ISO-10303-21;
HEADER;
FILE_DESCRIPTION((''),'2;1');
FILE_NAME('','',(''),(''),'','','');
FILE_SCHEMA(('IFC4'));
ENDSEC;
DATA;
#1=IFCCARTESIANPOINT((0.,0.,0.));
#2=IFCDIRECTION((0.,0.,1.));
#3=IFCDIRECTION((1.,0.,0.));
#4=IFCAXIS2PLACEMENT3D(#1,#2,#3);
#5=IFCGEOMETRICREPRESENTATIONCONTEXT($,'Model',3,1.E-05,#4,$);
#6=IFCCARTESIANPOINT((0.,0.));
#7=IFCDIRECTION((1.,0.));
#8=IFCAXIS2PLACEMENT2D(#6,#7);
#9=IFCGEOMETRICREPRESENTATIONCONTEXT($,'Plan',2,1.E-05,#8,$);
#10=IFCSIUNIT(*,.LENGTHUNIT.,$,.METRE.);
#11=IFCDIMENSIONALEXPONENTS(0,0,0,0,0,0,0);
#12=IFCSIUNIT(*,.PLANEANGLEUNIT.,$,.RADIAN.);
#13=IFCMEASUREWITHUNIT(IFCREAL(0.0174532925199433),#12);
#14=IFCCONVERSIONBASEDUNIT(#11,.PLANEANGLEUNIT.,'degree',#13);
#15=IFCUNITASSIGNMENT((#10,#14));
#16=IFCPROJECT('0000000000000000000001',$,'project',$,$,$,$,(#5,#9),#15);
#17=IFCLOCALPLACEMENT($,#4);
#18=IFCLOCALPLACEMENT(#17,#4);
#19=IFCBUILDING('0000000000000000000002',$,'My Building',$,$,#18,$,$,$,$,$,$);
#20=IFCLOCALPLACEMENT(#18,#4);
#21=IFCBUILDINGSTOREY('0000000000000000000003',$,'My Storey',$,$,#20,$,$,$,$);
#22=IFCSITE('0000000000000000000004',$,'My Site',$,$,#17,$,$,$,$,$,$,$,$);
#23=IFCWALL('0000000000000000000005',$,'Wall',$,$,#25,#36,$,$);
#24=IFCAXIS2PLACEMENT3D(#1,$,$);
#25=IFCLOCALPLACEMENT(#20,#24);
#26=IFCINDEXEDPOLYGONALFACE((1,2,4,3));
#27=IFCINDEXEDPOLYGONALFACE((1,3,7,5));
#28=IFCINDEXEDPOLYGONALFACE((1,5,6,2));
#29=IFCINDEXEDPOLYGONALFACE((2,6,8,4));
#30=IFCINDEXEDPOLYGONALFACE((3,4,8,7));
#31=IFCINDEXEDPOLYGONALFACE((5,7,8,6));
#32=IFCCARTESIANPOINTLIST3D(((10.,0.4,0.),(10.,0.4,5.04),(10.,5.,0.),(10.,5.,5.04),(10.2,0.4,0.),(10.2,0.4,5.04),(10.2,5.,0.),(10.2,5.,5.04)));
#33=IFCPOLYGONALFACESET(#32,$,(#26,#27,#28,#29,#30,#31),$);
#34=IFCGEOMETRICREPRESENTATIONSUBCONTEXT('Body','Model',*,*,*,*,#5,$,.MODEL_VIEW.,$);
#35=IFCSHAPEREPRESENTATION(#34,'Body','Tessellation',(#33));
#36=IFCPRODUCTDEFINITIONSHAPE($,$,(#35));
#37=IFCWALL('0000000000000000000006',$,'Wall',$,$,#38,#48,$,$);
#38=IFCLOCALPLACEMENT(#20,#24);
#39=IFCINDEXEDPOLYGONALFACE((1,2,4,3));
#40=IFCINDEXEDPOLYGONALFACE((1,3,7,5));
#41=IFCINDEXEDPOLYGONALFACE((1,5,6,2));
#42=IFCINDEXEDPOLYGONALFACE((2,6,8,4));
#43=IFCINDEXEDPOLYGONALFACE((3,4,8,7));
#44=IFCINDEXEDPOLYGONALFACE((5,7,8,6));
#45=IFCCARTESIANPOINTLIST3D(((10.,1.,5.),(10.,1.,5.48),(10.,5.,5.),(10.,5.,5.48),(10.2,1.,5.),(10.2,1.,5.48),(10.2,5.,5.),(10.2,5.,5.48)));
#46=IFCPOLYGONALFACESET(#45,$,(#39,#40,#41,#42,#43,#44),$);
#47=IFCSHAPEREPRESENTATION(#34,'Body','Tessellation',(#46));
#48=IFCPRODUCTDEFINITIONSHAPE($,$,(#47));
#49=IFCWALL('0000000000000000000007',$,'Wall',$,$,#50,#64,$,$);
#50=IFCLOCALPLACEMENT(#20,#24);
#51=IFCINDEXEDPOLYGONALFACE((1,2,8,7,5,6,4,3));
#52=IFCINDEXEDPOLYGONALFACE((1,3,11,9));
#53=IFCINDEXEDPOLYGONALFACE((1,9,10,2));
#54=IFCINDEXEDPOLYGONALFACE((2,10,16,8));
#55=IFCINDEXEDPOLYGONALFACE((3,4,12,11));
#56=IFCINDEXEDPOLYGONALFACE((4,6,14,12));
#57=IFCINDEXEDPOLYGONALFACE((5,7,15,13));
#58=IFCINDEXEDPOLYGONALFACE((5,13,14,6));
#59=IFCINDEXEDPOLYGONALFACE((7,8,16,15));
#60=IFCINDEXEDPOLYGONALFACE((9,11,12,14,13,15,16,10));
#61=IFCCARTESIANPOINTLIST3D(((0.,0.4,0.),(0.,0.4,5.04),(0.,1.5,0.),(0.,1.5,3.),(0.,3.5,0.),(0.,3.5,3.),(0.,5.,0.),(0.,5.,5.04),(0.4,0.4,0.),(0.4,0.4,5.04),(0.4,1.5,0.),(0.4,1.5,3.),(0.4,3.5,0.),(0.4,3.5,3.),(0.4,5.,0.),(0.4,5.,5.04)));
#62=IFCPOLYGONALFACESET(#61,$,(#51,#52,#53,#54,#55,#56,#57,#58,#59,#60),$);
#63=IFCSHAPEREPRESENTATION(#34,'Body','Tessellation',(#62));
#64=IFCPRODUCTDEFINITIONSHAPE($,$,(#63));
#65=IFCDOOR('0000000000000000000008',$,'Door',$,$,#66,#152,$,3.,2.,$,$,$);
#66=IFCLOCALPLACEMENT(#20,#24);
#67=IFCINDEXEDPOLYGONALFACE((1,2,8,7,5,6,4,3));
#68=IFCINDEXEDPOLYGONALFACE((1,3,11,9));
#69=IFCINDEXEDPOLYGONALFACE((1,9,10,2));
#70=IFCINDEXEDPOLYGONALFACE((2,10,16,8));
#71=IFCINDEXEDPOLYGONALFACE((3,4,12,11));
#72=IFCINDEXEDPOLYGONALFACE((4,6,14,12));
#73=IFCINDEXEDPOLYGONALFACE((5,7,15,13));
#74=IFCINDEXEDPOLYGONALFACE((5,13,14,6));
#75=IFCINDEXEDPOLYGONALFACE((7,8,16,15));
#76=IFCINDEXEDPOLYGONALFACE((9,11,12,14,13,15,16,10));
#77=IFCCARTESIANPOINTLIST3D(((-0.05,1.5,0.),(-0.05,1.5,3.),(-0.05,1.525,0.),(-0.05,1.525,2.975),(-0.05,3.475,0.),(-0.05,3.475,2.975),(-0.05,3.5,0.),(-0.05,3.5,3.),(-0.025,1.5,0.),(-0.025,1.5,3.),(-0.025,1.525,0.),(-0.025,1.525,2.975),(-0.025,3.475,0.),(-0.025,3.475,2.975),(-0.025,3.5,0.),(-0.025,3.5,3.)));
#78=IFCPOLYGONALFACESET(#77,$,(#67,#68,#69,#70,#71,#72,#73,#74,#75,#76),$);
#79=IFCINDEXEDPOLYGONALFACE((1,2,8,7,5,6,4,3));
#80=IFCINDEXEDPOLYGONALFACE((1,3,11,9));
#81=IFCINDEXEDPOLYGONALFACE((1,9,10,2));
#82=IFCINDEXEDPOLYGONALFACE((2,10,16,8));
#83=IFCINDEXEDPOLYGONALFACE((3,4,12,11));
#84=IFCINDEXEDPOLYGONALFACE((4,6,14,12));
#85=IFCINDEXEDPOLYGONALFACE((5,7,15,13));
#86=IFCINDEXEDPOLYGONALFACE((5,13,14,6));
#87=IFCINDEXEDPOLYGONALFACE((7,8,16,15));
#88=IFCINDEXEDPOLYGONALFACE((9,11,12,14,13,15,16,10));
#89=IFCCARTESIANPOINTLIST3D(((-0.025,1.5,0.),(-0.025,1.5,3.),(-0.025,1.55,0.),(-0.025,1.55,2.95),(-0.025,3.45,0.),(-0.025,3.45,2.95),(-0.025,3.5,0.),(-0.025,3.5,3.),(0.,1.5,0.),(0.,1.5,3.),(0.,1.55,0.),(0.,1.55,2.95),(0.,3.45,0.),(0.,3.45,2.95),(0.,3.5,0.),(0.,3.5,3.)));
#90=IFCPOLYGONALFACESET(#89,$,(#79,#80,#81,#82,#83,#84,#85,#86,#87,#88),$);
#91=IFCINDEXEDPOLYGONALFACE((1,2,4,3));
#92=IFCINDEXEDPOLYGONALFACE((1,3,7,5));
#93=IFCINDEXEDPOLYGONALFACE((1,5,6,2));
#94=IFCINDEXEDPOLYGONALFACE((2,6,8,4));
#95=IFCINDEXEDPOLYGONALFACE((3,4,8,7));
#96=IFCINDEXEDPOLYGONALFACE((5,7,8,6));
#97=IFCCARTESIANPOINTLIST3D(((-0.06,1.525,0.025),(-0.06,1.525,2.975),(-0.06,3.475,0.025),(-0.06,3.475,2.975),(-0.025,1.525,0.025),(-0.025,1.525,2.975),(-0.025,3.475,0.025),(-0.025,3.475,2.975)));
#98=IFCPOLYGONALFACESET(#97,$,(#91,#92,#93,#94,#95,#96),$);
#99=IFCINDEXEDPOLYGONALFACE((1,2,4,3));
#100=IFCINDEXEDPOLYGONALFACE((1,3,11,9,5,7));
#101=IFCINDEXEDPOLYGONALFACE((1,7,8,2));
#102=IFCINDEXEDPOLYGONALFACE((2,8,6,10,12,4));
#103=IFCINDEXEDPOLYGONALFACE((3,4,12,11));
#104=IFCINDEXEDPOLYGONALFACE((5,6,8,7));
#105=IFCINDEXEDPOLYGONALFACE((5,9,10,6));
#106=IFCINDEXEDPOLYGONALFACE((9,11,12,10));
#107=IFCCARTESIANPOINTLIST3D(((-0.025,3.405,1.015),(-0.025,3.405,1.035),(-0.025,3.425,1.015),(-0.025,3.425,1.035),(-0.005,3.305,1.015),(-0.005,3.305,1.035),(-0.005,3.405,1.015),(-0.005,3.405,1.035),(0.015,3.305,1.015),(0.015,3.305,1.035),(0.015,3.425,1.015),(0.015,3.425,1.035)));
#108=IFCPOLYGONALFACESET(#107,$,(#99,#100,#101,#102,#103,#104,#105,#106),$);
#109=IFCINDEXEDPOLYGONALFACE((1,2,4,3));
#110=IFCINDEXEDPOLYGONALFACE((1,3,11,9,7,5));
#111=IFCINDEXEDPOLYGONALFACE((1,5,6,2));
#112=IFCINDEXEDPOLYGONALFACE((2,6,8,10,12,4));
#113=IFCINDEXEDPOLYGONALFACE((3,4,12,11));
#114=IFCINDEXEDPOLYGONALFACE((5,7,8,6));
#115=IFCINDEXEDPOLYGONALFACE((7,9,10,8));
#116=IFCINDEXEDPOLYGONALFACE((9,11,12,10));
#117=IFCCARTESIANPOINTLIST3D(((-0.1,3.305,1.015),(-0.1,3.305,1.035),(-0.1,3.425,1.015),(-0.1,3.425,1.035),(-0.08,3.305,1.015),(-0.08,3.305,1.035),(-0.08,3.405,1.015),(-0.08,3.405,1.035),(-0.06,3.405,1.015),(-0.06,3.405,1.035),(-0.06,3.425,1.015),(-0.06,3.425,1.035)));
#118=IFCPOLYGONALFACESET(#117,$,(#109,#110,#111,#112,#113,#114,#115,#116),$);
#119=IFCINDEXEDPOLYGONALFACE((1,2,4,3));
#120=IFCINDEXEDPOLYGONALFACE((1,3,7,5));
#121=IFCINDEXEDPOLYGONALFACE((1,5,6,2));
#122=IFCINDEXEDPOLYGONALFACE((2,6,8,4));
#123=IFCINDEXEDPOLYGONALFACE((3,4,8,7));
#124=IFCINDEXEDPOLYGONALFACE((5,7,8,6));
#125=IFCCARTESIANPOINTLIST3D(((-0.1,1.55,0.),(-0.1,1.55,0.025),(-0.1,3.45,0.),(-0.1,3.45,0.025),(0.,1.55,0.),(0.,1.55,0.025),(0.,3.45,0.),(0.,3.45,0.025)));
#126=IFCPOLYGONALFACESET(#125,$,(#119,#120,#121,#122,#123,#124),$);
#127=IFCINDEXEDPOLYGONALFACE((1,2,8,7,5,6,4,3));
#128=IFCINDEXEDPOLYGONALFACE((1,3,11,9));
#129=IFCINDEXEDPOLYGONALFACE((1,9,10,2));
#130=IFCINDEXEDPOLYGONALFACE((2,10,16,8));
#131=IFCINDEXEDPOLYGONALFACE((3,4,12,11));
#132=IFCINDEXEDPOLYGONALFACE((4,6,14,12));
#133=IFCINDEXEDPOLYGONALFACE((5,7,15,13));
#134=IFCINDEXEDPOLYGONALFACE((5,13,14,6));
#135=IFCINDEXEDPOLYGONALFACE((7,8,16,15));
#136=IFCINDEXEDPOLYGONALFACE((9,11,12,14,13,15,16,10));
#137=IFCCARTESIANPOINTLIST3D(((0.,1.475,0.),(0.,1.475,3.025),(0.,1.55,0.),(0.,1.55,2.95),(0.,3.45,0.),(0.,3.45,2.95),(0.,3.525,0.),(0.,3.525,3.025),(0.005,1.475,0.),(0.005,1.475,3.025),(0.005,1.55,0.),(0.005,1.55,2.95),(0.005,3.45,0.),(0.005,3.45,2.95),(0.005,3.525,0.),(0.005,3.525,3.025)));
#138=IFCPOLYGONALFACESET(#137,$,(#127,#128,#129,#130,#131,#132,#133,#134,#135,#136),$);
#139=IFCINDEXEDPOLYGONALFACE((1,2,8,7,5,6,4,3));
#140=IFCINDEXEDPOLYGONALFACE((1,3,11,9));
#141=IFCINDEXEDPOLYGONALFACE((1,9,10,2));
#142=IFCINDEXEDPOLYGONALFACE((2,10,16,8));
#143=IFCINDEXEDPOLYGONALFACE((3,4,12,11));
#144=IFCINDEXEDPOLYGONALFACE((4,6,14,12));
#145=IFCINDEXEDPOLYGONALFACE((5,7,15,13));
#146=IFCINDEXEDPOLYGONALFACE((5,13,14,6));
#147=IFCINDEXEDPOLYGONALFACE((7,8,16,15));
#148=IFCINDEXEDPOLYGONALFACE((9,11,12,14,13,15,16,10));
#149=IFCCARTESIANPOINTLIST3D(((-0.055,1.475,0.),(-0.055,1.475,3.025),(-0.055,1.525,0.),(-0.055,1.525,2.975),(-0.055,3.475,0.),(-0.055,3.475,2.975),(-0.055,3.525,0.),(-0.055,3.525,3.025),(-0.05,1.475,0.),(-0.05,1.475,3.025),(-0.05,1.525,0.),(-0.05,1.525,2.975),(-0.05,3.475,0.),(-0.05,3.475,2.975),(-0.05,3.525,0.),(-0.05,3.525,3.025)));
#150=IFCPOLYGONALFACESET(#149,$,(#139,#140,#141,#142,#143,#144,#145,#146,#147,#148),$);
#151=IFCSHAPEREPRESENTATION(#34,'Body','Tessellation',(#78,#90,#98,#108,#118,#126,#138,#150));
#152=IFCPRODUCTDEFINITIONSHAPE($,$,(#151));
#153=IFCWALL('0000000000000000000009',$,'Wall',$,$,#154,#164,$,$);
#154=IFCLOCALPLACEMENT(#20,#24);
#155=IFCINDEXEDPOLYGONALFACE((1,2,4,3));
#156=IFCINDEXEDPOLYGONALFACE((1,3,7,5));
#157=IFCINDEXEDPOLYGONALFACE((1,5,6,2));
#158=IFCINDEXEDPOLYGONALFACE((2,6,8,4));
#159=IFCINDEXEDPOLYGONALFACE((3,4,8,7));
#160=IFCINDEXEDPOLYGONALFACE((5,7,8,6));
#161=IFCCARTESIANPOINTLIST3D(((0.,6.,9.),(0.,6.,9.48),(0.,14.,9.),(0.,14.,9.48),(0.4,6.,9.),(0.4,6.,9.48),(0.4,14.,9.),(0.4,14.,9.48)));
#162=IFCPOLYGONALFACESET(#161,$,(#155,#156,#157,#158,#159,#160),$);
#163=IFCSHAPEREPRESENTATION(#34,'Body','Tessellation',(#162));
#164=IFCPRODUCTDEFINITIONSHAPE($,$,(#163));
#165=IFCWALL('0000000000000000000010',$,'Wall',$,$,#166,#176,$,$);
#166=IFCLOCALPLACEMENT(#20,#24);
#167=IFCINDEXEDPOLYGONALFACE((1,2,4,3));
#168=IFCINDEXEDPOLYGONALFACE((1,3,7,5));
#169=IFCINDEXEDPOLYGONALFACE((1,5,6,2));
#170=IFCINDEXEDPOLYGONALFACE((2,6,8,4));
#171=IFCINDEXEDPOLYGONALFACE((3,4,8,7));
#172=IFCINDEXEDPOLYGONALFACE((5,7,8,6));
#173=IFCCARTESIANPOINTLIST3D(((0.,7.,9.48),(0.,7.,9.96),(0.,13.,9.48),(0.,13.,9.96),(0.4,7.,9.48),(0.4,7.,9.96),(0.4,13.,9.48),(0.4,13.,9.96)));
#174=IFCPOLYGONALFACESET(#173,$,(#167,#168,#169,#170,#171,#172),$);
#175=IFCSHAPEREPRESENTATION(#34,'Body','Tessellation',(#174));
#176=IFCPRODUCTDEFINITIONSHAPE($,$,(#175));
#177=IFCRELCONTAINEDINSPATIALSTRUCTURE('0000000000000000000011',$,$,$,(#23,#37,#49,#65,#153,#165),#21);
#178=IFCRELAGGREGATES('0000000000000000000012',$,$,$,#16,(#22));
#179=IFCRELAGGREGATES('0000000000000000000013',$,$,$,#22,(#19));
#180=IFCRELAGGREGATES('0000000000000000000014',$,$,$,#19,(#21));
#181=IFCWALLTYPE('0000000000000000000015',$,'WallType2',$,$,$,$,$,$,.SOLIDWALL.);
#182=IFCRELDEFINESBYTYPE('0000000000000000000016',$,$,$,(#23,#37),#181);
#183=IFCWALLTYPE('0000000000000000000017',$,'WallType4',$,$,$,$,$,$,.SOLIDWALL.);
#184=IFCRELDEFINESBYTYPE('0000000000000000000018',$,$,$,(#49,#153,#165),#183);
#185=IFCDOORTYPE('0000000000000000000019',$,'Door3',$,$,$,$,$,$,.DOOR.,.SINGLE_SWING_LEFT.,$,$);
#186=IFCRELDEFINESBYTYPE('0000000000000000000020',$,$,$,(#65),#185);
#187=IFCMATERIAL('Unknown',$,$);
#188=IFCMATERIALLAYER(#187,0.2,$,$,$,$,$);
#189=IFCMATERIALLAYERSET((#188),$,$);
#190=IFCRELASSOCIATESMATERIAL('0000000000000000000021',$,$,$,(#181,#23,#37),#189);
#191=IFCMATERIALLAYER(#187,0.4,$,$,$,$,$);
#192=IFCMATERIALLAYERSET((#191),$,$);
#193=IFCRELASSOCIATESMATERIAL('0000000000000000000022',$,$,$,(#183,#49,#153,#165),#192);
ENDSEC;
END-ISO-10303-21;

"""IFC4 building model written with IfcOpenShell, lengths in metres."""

from ifc_helpers import new_model, entity, si_unit, converted_unit, frame, origin_with_axes, origin_2d_with_axis, place, context, subcontext, project, spatial, line, indexed_curve, outline, extrude, shape, source, transform, mapped, material, layer, layer_set, layer_usage, type_object, type_shapes, element, fill, save


model = new_model("IFC4")

# Units and contexts
model_context = context("Model", 3, precision=1e-05, world=origin_with_axes())
plan_context = context("Plan", 2, precision=1e-05, world=origin_2d_with_axis())
body_context_1 = subcontext(model_context, "Body", "Model", "MODEL_VIEW")
body_context_2 = subcontext(plan_context, "Body", "Plan", "PLAN_VIEW")
ifc_project = project(units=[si_unit("LENGTHUNIT", "METRE"), converted_unit("PLANEANGLEUNIT", "degree", entity("IfcReal", 0.0174532925199433), si_unit("PLANEANGLEUNIT", "RADIAN"), dimensions=[0, 0, 0, 0, 0, 0, 0])], contexts=[model_context, plan_context])

# Site, building, storey
site_placement = place(None, origin_with_axes())
site = spatial("IfcSite", under=ifc_project, at=site_placement, Name="My Site")
building_placement = place(site_placement, origin_with_axes())
building = spatial("IfcBuilding", under=site, at=building_placement, Name="My Building")
storey_placement = place(building_placement, origin_with_axes())
storey = spatial("IfcBuildingStorey", under=building, at=storey_placement, Name="My Storey")

# Walls
ifc_material = material(Name="Unknown")
ifc_layer_1 = layer(ifc_material, 0.2)
ifc_layer_set_1 = layer_set([ifc_layer_1])
ifc_layer_usage_1 = layer_usage(ifc_layer_set_1, "AXIS2", "POSITIVE", 0.0)
wall_type_1 = type_object("IfcWallType", Name="WallType2", PredefinedType="SOLIDWALL", material=ifc_layer_set_1)
wall_1_placement = place(storey_placement, frame((10.2, 0.4, 0.0), z_axis=(0.0, 0.0, 1.0), x_axis=(0.0, 1.0, 0.0)))
element("IfcWall", 1, at=wall_1_placement, inside=storey, type_object=wall_type_1, material=ifc_layer_usage_1, Name="Wall", context=body_context_1, shape_type="SweptSolid", body=[
    extrude(outline(indexed_curve([(0.0, 0.0), (0.0, 0.2), (4.6, 0.2), (4.6, 0.0), (0.0, 0.0)], self_intersect=False)), origin_with_axes(), (0.0, 0.0, 1.0), 5.04),
])
ifc_layer_usage_2 = layer_usage(ifc_layer_set_1, "AXIS2", "POSITIVE", 0.0)
wall_2_placement = place(storey_placement, frame((10.2, 1.0, 5.0), z_axis=(0.0, 0.0, 1.0), x_axis=(0.0, 1.0, 0.0)))
element("IfcWall", 2, at=wall_2_placement, inside=storey, type_object=wall_type_1, material=ifc_layer_usage_2, Name="Wall", context=body_context_1, shape_type="SweptSolid", body=[
    extrude(outline(indexed_curve([(0.0, 0.0), (0.0, 0.2), (4.0, 0.2), (4.0, 0.0), (0.0, 0.0)], self_intersect=False)), origin_with_axes(), (0.0, 0.0, 1.0), 0.48),
])

# Shared definitions
ifc_layer_2 = layer(ifc_material, 0.4)
ifc_layer_set_2 = layer_set([ifc_layer_2])
wall_type_2 = type_object("IfcWallType", Name="WallType4", PredefinedType="SOLIDWALL", material=ifc_layer_set_2)

# Wall, opening, door
ifc_layer_usage_3 = layer_usage(ifc_layer_set_2, "AXIS2", "POSITIVE", 0.0)
wall_3_placement = place(storey_placement, frame((0.4, 0.4, 0.0), z_axis=(0.0, 0.0, 1.0), x_axis=(0.0, 1.0, 0.0)))
wall_3 = element("IfcWall", 3, at=wall_3_placement, inside=storey, type_object=wall_type_2, material=ifc_layer_usage_3, Name="Wall", context=body_context_1, shape_type="SweptSolid", body=[
    extrude(outline(indexed_curve([(0.0, 0.0), (0.0, 0.4), (4.6, 0.4), (4.6, 0.0), (0.0, 0.0)], self_intersect=False)), origin_with_axes(), (0.0, 0.0, 1.0), 5.04),
])
shared_shape_1 = source(origin_with_axes(), body_context_1, "Body", "SweptSolid", [
    extrude(outline(indexed_curve([(0.0, 0.0), (2.0, 0.0), (2.0, 3.0), (0.0, 3.0)], segments=[line(1, 2, 3, 4, 1)])), frame((0.0, -0.6, 0.0), z_axis=(0.0, -1.0, 0.0), x_axis=(1.0, 0.0, 0.0)), (0.0, 0.0, -1.0), 1.2),
])
opening_1_placement = place(wall_3_placement, frame((1.1, 0.0, 0.0), z_axis=(0.0, 0.0, 1.0), x_axis=(1.0, 0.0, 0.0)))
opening_1 = element("IfcOpeningElement", 4, at=opening_1_placement, cuts=wall_3, PredefinedType="OPENING", context=body_context_1, shape_type="MappedRepresentation", body=[
    mapped(shared_shape_1, transform((0.0, 0.0, 0.0), x_axis=(1.0, 0.0, 0.0), y_axis=(0.0, 1.0, 0.0), z_axis=(0.0, 0.0, 1.0), scale=1.0)),
])
door_type_1 = type_object("IfcDoorType", Name="Door3", OperationType="SINGLE_SWING_LEFT", PredefinedType="DOOR")
shared_shape_2 = source(origin_with_axes(), body_context_1, "Body", "SweptSolid", [
    extrude(outline(indexed_curve([(0.0, 0.0), (0.0, 3.0), (2.0, 3.0), (2.0, 0.0), (1.975, 0.0), (1.975, 2.975), (0.025, 2.975), (0.025, 0.0)], segments=[line(1, 2, 3, 4, 5, 6, 7, 8, 1)])), frame((0.0, 0.025, 0.0), z_axis=(0.0, -1.0, 0.0), x_axis=(1.0, 0.0, 0.0)), (0.0, 0.0, -1.0), 0.025),
    extrude(outline(indexed_curve([(0.0, 0.0), (0.0, 3.0), (2.0, 3.0), (2.0, 0.0), (1.95, 0.0), (1.95, 2.95), (0.05, 2.95), (0.05, 0.0)], segments=[line(1, 2, 3, 4, 5, 6, 7, 8, 1)])), frame((0.0, 0.0, 0.0), z_axis=(0.0, -1.0, 0.0), x_axis=(1.0, 0.0, 0.0)), (0.0, 0.0, -1.0), 0.025),
    extrude(outline(indexed_curve([(0.0, 0.0), (1.95, 0.0), (1.95, 0.035), (0.0, 0.035)], segments=[line(1, 2, 3, 4, 1)])), frame((0.025, 0.025, 0.025), z_axis=(0.0, 0.0, 1.0), x_axis=(1.0, 0.0, 0.0)), (0.0, 0.0, 1.0), 2.95),
    extrude(outline(indexed_curve([(0.0, 0.0), (0.0, -0.04), (-0.12, -0.04), (-0.12, -0.02), (-0.02, -0.02), (-0.02, 0.0)], segments=[line(1, 2, 3, 4, 5, 6, 1)])), frame((1.925, 0.025, 1.015), z_axis=(0.0, 0.0, 1.0), x_axis=(1.0, 0.0, 0.0)), (0.0, 0.0, 1.0), 0.02),
    extrude(outline(indexed_curve([(0.0, 0.0), (0.0, 0.04), (-0.12, 0.04), (-0.12, 0.02), (-0.02, 0.02), (-0.02, 0.0)], segments=[line(1, 2, 3, 4, 5, 6, 1)])), frame((1.925, 0.06, 1.015), z_axis=(0.0, 0.0, 1.0), x_axis=(1.0, 0.0, 0.0)), (0.0, 0.0, 1.0), 0.02),
    extrude(outline(indexed_curve([(0.0, 0.0), (1.9, 0.0), (1.9, 0.1), (0.0, 0.1)], segments=[line(1, 2, 3, 4, 1)])), frame((0.05, 0.0, 0.0), z_axis=(0.0, 0.0, 1.0), x_axis=(1.0, 0.0, 0.0)), (0.0, 0.0, 1.0), 0.025),
    extrude(outline(indexed_curve([(0.0, 0.0), (0.0, 3.025), (2.05, 3.025), (2.05, 0.0), (1.975, 0.0), (1.975, 2.95), (0.075, 2.95), (0.075, 0.0)], segments=[line(1, 2, 3, 4, 5, 6, 7, 8, 1)])), frame((-0.025, -0.005, 0.0), z_axis=(0.0, -1.0, 0.0), x_axis=(1.0, 0.0, 0.0)), (0.0, 0.0, -1.0), 0.005),
    extrude(outline(indexed_curve([(0.0, 0.0), (0.0, 3.025), (2.05, 3.025), (2.05, 0.0), (2.0, 0.0), (2.0, 2.975), (0.05, 2.975), (0.05, 0.0)], segments=[line(1, 2, 3, 4, 5, 6, 7, 8, 1)])), frame((-0.025, 0.05, 0.0), z_axis=(0.0, -1.0, 0.0), x_axis=(1.0, 0.0, 0.0)), (0.0, 0.0, -1.0), 0.005),
])
shared_shape_3 = source(origin_with_axes(), body_context_2, "Body", "Curve2D", [
    entity("IfcIndexedPolyCurve", entity("IfcCartesianPointList2D", [[0.0, 0.0], [0.0, 0.05], [0.025, 0.05], [0.025, 0.025], [0.05, 0.025], [0.05, 0.0]]), [entity("IfcLineIndex", [1, 2, 3, 4, 5, 6, 1])]),
    entity("IfcIndexedPolyCurve", entity("IfcCartesianPointList2D", [[2.0, 0.0], [2.0, 0.05], [1.975, 0.05], [1.975, 0.025], [1.95, 0.025], [1.95, 0.0]]), [entity("IfcLineIndex", [1, 2, 3, 4, 5, 6, 1])]),
    entity("IfcTrimmedCurve", entity("IfcEllipse", entity("IfcAxis2Placement2D", entity("IfcCartesianPoint", [0.06, 0.05]), entity("IfcDirection", [1.0, 0.0])), 1.915, 1.95), [entity("IfcCartesianPoint", [1.975, 0.05])], [entity("IfcCartesianPoint", [0.06, 2.0])], True, "CARTESIAN"),
    entity("IfcIndexedPolyCurve", entity("IfcCartesianPointList2D", [[0.025, 0.05], [0.06, 0.05], [0.06, 2.0], [0.025, 2.0]]), [entity("IfcLineIndex", [1, 2, 3, 4, 1])]),
])
type_shapes(door_type_1, [shared_shape_2, shared_shape_3])
door_1_placement = place(opening_1_placement, frame((0.0, 0.4, 0.0), z_axis=(0.0, 0.0, 1.0), x_axis=(1.0, 0.0, 0.0)))
door_1 = element("IfcDoor", 5, at=door_1_placement, inside=storey, type_object=door_type_1, Name="Door", OverallHeight=3.0, OverallWidth=2.0, shapes=[
    shape(body_context_1, "Body", "MappedRepresentation", [mapped(shared_shape_2, transform((0.0, 0.0, 0.0), x_axis=(1.0, 0.0, 0.0), y_axis=(0.0, 1.0, 0.0), z_axis=(0.0, 0.0, 1.0), scale=1.0))]),
    shape(body_context_2, "Body", "MappedRepresentation", [mapped(shared_shape_3, transform((0.0, 0.0, 0.0), x_axis=(1.0, 0.0, 0.0), y_axis=(0.0, 1.0, 0.0), z_axis=(0.0, 0.0, 1.0), scale=1.0))]),
])
fill(opening_1, door_1)

# Walls
ifc_layer_usage_4 = layer_usage(ifc_layer_set_2, "AXIS2", "POSITIVE", 0.0)
wall_4_placement = place(storey_placement, frame((0.4, 6.0, 9.0), z_axis=(0.0, 0.0, 1.0), x_axis=(0.0, 1.0, 0.0)))
element("IfcWall", 6, at=wall_4_placement, inside=storey, type_object=wall_type_2, material=ifc_layer_usage_4, Name="Wall", context=body_context_1, shape_type="SweptSolid", body=[
    extrude(outline(indexed_curve([(0.0, 0.0), (0.0, 0.4), (8.0, 0.4), (8.0, 0.0), (0.0, 0.0)], self_intersect=False)), origin_with_axes(), (0.0, 0.0, 1.0), 0.48),
])
ifc_layer_usage_5 = layer_usage(ifc_layer_set_2, "AXIS2", "POSITIVE", 0.0)
wall_5_placement = place(storey_placement, frame((0.4, 7.0, 9.48), z_axis=(0.0, 0.0, 1.0), x_axis=(0.0, 1.0, 0.0)))
element("IfcWall", 7, at=wall_5_placement, inside=storey, type_object=wall_type_2, material=ifc_layer_usage_5, Name="Wall", context=body_context_1, shape_type="SweptSolid", body=[
    extrude(outline(indexed_curve([(0.0, 0.0), (0.0, 0.4), (6.0, 0.4), (6.0, 0.0), (0.0, 0.0)], self_intersect=False)), origin_with_axes(), (0.0, 0.0, 1.0), 0.48),
])

save(model, "model.ifc")
